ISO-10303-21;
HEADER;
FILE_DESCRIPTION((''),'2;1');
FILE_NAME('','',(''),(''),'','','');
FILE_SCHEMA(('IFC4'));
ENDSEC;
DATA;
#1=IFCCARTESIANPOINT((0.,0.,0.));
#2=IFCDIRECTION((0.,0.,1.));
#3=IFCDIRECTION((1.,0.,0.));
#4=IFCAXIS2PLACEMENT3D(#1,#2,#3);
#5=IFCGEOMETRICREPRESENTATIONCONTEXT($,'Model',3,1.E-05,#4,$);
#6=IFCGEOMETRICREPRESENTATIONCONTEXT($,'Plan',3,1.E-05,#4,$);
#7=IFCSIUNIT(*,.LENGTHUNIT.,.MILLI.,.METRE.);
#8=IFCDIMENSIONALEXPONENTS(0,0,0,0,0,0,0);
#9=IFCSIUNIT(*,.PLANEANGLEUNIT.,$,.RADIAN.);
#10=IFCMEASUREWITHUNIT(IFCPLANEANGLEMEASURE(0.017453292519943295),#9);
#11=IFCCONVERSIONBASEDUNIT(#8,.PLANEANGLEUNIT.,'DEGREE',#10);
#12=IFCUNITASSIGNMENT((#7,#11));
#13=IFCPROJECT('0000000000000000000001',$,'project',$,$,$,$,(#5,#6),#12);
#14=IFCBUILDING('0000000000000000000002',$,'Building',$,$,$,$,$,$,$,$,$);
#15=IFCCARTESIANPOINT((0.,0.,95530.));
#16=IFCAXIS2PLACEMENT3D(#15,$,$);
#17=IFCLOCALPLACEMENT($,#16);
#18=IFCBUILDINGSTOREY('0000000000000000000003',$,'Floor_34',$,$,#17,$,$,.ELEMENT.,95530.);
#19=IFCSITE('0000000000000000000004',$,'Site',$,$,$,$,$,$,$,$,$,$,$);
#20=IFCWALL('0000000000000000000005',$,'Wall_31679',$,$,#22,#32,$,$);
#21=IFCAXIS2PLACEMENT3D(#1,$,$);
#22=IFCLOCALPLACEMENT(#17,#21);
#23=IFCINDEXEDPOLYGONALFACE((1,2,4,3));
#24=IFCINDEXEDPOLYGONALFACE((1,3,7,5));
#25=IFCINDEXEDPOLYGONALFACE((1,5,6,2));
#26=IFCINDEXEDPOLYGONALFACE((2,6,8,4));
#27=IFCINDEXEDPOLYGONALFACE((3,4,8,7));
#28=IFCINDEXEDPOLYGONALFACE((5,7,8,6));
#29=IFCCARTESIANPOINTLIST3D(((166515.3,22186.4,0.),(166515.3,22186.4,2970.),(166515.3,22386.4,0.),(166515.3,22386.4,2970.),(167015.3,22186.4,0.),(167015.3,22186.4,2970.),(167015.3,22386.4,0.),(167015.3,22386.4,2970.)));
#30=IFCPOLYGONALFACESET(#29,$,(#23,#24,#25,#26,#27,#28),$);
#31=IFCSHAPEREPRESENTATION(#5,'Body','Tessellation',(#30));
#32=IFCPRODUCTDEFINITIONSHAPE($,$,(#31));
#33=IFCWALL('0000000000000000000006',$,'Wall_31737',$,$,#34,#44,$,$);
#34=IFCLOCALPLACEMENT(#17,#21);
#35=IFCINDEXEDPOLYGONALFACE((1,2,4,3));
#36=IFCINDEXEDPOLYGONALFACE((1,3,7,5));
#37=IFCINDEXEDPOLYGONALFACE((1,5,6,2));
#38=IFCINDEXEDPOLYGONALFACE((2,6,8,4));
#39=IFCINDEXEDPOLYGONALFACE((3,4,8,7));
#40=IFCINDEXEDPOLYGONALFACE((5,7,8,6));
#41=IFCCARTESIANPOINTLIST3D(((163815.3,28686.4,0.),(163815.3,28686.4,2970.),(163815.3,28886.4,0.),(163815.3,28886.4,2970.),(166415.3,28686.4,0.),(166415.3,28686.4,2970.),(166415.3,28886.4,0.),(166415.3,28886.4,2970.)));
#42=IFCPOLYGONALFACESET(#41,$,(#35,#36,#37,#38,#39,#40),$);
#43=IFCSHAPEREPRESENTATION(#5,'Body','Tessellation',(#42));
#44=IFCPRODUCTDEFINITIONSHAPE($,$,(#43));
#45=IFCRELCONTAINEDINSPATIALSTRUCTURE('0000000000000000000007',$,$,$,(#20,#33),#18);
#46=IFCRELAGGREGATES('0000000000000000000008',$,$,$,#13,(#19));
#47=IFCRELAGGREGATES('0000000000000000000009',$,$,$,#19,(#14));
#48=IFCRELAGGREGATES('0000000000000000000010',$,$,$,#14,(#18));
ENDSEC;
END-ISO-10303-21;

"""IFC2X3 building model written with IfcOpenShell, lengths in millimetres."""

from ifc_helpers import new_model, entity, si_unit, converted_unit, frame, origin_with_axes, origin_2d, place, context, project, spatial, rectangle, extrude, element, save


model = new_model("IFC2X3")

# Units and contexts
model_context = context("Model", 3, precision=1e-05, world=origin_with_axes())
plan_context = context("Plan", 3, precision=1e-05, world=origin_with_axes())
ifc_project = project(units=[si_unit("LENGTHUNIT", "METRE", prefix="MILLI"), converted_unit("PLANEANGLEUNIT", "DEGREE", entity("IfcPlaneAngleMeasure", 0.017453292519943295), si_unit("PLANEANGLEUNIT", "RADIAN"), dimensions=[0, 0, 0, 0, 0, 0, 0])], contexts=[model_context, plan_context])

# Site, building, storey
site = spatial("IfcSite", under=ifc_project, Name="Site")
building = spatial("IfcBuilding", under=site, Name="Building")
storey_placement = place(None, frame((0.0, 0.0, 95530.0)))
storey = spatial("IfcBuildingStorey", under=building, at=storey_placement, Name="Floor_34", CompositionType="ELEMENT", Elevation=95530.0)

# Walls
wall_1_placement = place(storey_placement, frame((166765.3, 22286.4, 0.0), z_axis=(0.0, 0.0, 1.0), x_axis=(500.0, 0.0, 0.0)))
element("IfcWall", 1, at=wall_1_placement, inside=storey, Name="Wall_31679", context=model_context, shape_type="SweptSolid", body=[
    extrude(rectangle(XDim=500.0, YDim=200.0, at=origin_2d()), origin_with_axes(), (0.0, 0.0, 1.0), 2970.0),
])
wall_2_placement = place(storey_placement, frame((165115.3, 28786.4, 0.0), z_axis=(0.0, 0.0, 1.0), x_axis=(2600.0, 0.0, 0.0)))
element("IfcWall", 2, at=wall_2_placement, inside=storey, Name="Wall_31737", context=model_context, shape_type="SweptSolid", body=[
    extrude(rectangle(XDim=2600.0, YDim=200.0, at=origin_2d()), origin_with_axes(), (0.0, 0.0, 1.0), 2970.0),
])

save(model, "model.ifc")
